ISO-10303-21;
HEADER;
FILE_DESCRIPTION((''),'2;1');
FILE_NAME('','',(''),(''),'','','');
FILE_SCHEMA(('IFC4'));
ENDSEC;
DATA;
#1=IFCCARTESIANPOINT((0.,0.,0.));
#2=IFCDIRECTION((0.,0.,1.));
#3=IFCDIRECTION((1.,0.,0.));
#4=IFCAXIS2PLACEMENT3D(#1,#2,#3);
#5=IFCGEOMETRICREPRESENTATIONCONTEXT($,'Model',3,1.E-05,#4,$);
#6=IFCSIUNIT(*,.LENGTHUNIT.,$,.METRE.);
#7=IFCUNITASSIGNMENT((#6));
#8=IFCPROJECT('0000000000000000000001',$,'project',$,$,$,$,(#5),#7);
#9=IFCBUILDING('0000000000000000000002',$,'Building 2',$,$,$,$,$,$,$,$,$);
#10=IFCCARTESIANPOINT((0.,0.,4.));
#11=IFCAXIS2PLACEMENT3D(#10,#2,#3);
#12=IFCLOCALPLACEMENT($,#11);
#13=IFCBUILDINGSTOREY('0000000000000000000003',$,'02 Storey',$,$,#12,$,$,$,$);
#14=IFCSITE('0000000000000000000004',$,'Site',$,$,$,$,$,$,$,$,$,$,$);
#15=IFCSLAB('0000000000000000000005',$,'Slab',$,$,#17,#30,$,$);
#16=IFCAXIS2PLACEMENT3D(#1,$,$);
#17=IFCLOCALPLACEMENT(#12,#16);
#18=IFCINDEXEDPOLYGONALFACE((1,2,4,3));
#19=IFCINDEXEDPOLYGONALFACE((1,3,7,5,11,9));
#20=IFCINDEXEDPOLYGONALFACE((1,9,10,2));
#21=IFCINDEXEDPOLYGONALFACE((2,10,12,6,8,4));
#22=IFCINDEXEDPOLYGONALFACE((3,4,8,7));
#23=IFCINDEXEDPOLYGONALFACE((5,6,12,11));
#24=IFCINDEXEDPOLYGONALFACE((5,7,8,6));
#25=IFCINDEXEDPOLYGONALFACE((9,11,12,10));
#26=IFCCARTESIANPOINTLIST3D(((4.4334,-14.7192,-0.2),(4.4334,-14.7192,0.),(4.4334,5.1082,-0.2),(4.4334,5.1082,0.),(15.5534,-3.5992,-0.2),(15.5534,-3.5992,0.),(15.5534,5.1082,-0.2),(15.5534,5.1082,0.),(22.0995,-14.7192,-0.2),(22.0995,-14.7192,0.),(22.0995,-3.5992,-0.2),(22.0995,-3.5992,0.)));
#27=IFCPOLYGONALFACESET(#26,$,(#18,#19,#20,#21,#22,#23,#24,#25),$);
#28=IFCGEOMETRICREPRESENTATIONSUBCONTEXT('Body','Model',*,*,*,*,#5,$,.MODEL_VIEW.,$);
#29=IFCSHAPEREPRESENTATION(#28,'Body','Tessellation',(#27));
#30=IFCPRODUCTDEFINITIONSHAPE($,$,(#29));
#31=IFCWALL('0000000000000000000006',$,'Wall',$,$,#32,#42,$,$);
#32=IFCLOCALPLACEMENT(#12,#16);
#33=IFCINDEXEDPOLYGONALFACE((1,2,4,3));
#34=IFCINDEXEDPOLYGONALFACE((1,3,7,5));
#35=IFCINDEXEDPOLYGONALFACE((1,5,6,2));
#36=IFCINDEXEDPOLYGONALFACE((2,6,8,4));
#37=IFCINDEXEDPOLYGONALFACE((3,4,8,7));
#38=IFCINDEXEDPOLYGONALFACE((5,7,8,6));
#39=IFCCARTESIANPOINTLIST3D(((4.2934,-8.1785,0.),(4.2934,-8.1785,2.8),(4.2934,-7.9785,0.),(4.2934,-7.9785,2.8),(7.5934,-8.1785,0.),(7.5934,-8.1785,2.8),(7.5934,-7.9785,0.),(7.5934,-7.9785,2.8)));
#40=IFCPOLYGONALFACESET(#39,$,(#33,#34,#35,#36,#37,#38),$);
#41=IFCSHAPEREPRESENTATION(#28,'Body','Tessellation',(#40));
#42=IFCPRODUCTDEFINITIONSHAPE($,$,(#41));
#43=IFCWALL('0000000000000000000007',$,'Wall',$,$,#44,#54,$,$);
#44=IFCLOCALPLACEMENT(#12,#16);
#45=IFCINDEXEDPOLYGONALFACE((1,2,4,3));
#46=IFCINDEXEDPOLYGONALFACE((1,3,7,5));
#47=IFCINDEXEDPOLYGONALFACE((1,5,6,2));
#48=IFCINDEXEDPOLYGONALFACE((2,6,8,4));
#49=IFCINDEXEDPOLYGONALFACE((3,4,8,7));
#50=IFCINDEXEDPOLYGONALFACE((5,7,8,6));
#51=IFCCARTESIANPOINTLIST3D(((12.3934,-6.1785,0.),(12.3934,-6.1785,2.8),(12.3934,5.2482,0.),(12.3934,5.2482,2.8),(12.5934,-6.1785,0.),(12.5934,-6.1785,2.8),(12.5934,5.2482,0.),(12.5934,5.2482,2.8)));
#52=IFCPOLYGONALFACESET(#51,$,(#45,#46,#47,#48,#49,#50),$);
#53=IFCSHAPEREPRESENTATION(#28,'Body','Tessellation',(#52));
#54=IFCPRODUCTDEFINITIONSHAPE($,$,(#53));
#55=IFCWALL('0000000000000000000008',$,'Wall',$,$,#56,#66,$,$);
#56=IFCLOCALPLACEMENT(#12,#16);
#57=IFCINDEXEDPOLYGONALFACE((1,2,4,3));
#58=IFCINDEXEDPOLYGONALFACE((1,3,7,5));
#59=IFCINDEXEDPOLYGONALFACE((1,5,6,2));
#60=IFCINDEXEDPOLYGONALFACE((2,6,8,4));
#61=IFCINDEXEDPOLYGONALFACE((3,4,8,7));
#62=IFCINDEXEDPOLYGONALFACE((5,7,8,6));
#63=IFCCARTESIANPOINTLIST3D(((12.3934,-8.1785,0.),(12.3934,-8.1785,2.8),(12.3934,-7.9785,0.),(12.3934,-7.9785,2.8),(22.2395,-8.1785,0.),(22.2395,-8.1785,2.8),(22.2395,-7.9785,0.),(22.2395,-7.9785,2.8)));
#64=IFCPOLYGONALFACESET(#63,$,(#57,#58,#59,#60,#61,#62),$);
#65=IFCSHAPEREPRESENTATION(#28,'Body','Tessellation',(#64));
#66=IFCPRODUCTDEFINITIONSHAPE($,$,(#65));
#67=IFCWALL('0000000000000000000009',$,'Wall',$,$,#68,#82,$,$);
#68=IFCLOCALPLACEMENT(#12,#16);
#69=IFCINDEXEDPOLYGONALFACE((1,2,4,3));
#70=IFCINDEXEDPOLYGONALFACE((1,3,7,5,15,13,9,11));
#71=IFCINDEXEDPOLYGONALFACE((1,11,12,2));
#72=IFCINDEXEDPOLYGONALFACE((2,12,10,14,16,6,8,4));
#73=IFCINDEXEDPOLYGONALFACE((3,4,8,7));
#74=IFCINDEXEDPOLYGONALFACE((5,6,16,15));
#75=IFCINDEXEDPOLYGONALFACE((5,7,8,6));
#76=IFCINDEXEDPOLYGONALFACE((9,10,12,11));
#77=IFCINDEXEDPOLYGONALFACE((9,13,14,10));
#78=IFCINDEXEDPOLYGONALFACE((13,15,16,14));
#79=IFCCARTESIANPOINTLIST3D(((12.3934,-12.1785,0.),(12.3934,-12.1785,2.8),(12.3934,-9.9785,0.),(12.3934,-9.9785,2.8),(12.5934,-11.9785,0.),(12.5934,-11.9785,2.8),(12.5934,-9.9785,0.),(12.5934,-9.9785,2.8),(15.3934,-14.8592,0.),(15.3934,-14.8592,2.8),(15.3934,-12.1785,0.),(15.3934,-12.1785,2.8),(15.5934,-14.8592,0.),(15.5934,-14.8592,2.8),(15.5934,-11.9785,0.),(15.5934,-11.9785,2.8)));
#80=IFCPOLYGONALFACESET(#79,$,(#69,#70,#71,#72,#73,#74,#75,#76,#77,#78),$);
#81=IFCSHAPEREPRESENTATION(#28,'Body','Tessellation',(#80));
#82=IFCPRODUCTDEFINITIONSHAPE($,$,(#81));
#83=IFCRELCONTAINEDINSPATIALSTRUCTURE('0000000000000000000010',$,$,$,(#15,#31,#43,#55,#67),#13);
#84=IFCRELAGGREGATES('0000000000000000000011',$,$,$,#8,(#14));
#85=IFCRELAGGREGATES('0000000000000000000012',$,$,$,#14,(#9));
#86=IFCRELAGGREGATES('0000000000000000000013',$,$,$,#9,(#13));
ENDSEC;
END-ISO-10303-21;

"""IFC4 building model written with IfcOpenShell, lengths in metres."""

from ifc_helpers import new_model, si_unit, frame, origin_with_axes, place, context, subcontext, project, spatial, line, indexed_curve, outline, extrude, element, save


model = new_model("IFC4")

# Units and contexts
model_context = context("Model", 3, precision=1e-05, world=origin_with_axes())
body_context = subcontext(model_context, "Body", "Model", "MODEL_VIEW")
ifc_project = project(units=[si_unit("LENGTHUNIT", "METRE")], contexts=[model_context])

# Site, building, storey
site = spatial("IfcSite", under=ifc_project, Name="Site")
building = spatial("IfcBuilding", under=site, Name="Building 2")
storey_placement = place(None, frame((0.0, 0.0, 4.0), z_axis=(0.0, 0.0, 1.0), x_axis=(1.0, 0.0, 0.0)))
storey = spatial("IfcBuildingStorey", under=building, at=storey_placement, Name="02 Storey")

# Slab
slab_placement = place(storey_placement, origin_with_axes())
element("IfcSlab", 1, at=slab_placement, inside=storey, Name="Slab", context=body_context, shape_type="SweptSolid", body=[
    extrude(outline(indexed_curve([(22.0995, -3.5992), (15.5534, -3.5992), (15.5534, 5.1082), (4.4334, 5.1082), (4.4334, -14.7192), (22.0995, -14.7192)], segments=[line(1, 2), line(2, 3), line(3, 4), line(4, 5), line(5, 6)])), origin_with_axes(), (0.0, 0.0, -1.0), 0.2),
])

# Walls
wall_1_placement = place(storey_placement, origin_with_axes())
element("IfcWall", 2, at=wall_1_placement, inside=storey, Name="Wall", context=body_context, shape_type="SweptSolid", body=[
    extrude(outline(indexed_curve([(7.5934, -7.9785), (4.2934, -7.9785), (4.2934, -8.1785), (7.5934, -8.1785)], segments=[line(1, 2), line(2, 3), line(3, 4)])), origin_with_axes(), (0.0, 0.0, 1.0), 2.8),
])
wall_2_placement = place(storey_placement, origin_with_axes())
element("IfcWall", 3, at=wall_2_placement, inside=storey, Name="Wall", context=body_context, shape_type="SweptSolid", body=[
    extrude(outline(indexed_curve([(12.5934, 5.2482), (12.3934, 5.2482), (12.3934, -6.1785), (12.5934, -6.1785)], segments=[line(1, 2), line(2, 3), line(3, 4)])), origin_with_axes(), (0.0, 0.0, 1.0), 2.8),
])
wall_3_placement = place(storey_placement, origin_with_axes())
element("IfcWall", 4, at=wall_3_placement, inside=storey, Name="Wall", context=body_context, shape_type="SweptSolid", body=[
    extrude(outline(indexed_curve([(22.2395, -7.9785), (12.3934, -7.9785), (12.3934, -8.1785), (22.2395, -8.1785)], segments=[line(1, 2), line(2, 3), line(3, 4)])), origin_with_axes(), (0.0, 0.0, 1.0), 2.8),
])
wall_4_placement = place(storey_placement, origin_with_axes())
element("IfcWall", 5, at=wall_4_placement, inside=storey, Name="Wall", context=body_context, shape_type="SweptSolid", body=[
    extrude(outline(indexed_curve([(15.5934, -11.9785), (12.5934, -11.9785), (12.5934, -9.9785), (12.3934, -9.9785), (12.3934, -12.1785), (15.3934, -12.1785), (15.3934, -14.8592), (15.5934, -14.8592)], segments=[line(1, 2), line(2, 3), line(3, 4), line(4, 5), line(5, 6), line(6, 7), line(7, 8)])), origin_with_axes(), (0.0, 0.0, 1.0), 2.8),
])

save(model, "model.ifc")
